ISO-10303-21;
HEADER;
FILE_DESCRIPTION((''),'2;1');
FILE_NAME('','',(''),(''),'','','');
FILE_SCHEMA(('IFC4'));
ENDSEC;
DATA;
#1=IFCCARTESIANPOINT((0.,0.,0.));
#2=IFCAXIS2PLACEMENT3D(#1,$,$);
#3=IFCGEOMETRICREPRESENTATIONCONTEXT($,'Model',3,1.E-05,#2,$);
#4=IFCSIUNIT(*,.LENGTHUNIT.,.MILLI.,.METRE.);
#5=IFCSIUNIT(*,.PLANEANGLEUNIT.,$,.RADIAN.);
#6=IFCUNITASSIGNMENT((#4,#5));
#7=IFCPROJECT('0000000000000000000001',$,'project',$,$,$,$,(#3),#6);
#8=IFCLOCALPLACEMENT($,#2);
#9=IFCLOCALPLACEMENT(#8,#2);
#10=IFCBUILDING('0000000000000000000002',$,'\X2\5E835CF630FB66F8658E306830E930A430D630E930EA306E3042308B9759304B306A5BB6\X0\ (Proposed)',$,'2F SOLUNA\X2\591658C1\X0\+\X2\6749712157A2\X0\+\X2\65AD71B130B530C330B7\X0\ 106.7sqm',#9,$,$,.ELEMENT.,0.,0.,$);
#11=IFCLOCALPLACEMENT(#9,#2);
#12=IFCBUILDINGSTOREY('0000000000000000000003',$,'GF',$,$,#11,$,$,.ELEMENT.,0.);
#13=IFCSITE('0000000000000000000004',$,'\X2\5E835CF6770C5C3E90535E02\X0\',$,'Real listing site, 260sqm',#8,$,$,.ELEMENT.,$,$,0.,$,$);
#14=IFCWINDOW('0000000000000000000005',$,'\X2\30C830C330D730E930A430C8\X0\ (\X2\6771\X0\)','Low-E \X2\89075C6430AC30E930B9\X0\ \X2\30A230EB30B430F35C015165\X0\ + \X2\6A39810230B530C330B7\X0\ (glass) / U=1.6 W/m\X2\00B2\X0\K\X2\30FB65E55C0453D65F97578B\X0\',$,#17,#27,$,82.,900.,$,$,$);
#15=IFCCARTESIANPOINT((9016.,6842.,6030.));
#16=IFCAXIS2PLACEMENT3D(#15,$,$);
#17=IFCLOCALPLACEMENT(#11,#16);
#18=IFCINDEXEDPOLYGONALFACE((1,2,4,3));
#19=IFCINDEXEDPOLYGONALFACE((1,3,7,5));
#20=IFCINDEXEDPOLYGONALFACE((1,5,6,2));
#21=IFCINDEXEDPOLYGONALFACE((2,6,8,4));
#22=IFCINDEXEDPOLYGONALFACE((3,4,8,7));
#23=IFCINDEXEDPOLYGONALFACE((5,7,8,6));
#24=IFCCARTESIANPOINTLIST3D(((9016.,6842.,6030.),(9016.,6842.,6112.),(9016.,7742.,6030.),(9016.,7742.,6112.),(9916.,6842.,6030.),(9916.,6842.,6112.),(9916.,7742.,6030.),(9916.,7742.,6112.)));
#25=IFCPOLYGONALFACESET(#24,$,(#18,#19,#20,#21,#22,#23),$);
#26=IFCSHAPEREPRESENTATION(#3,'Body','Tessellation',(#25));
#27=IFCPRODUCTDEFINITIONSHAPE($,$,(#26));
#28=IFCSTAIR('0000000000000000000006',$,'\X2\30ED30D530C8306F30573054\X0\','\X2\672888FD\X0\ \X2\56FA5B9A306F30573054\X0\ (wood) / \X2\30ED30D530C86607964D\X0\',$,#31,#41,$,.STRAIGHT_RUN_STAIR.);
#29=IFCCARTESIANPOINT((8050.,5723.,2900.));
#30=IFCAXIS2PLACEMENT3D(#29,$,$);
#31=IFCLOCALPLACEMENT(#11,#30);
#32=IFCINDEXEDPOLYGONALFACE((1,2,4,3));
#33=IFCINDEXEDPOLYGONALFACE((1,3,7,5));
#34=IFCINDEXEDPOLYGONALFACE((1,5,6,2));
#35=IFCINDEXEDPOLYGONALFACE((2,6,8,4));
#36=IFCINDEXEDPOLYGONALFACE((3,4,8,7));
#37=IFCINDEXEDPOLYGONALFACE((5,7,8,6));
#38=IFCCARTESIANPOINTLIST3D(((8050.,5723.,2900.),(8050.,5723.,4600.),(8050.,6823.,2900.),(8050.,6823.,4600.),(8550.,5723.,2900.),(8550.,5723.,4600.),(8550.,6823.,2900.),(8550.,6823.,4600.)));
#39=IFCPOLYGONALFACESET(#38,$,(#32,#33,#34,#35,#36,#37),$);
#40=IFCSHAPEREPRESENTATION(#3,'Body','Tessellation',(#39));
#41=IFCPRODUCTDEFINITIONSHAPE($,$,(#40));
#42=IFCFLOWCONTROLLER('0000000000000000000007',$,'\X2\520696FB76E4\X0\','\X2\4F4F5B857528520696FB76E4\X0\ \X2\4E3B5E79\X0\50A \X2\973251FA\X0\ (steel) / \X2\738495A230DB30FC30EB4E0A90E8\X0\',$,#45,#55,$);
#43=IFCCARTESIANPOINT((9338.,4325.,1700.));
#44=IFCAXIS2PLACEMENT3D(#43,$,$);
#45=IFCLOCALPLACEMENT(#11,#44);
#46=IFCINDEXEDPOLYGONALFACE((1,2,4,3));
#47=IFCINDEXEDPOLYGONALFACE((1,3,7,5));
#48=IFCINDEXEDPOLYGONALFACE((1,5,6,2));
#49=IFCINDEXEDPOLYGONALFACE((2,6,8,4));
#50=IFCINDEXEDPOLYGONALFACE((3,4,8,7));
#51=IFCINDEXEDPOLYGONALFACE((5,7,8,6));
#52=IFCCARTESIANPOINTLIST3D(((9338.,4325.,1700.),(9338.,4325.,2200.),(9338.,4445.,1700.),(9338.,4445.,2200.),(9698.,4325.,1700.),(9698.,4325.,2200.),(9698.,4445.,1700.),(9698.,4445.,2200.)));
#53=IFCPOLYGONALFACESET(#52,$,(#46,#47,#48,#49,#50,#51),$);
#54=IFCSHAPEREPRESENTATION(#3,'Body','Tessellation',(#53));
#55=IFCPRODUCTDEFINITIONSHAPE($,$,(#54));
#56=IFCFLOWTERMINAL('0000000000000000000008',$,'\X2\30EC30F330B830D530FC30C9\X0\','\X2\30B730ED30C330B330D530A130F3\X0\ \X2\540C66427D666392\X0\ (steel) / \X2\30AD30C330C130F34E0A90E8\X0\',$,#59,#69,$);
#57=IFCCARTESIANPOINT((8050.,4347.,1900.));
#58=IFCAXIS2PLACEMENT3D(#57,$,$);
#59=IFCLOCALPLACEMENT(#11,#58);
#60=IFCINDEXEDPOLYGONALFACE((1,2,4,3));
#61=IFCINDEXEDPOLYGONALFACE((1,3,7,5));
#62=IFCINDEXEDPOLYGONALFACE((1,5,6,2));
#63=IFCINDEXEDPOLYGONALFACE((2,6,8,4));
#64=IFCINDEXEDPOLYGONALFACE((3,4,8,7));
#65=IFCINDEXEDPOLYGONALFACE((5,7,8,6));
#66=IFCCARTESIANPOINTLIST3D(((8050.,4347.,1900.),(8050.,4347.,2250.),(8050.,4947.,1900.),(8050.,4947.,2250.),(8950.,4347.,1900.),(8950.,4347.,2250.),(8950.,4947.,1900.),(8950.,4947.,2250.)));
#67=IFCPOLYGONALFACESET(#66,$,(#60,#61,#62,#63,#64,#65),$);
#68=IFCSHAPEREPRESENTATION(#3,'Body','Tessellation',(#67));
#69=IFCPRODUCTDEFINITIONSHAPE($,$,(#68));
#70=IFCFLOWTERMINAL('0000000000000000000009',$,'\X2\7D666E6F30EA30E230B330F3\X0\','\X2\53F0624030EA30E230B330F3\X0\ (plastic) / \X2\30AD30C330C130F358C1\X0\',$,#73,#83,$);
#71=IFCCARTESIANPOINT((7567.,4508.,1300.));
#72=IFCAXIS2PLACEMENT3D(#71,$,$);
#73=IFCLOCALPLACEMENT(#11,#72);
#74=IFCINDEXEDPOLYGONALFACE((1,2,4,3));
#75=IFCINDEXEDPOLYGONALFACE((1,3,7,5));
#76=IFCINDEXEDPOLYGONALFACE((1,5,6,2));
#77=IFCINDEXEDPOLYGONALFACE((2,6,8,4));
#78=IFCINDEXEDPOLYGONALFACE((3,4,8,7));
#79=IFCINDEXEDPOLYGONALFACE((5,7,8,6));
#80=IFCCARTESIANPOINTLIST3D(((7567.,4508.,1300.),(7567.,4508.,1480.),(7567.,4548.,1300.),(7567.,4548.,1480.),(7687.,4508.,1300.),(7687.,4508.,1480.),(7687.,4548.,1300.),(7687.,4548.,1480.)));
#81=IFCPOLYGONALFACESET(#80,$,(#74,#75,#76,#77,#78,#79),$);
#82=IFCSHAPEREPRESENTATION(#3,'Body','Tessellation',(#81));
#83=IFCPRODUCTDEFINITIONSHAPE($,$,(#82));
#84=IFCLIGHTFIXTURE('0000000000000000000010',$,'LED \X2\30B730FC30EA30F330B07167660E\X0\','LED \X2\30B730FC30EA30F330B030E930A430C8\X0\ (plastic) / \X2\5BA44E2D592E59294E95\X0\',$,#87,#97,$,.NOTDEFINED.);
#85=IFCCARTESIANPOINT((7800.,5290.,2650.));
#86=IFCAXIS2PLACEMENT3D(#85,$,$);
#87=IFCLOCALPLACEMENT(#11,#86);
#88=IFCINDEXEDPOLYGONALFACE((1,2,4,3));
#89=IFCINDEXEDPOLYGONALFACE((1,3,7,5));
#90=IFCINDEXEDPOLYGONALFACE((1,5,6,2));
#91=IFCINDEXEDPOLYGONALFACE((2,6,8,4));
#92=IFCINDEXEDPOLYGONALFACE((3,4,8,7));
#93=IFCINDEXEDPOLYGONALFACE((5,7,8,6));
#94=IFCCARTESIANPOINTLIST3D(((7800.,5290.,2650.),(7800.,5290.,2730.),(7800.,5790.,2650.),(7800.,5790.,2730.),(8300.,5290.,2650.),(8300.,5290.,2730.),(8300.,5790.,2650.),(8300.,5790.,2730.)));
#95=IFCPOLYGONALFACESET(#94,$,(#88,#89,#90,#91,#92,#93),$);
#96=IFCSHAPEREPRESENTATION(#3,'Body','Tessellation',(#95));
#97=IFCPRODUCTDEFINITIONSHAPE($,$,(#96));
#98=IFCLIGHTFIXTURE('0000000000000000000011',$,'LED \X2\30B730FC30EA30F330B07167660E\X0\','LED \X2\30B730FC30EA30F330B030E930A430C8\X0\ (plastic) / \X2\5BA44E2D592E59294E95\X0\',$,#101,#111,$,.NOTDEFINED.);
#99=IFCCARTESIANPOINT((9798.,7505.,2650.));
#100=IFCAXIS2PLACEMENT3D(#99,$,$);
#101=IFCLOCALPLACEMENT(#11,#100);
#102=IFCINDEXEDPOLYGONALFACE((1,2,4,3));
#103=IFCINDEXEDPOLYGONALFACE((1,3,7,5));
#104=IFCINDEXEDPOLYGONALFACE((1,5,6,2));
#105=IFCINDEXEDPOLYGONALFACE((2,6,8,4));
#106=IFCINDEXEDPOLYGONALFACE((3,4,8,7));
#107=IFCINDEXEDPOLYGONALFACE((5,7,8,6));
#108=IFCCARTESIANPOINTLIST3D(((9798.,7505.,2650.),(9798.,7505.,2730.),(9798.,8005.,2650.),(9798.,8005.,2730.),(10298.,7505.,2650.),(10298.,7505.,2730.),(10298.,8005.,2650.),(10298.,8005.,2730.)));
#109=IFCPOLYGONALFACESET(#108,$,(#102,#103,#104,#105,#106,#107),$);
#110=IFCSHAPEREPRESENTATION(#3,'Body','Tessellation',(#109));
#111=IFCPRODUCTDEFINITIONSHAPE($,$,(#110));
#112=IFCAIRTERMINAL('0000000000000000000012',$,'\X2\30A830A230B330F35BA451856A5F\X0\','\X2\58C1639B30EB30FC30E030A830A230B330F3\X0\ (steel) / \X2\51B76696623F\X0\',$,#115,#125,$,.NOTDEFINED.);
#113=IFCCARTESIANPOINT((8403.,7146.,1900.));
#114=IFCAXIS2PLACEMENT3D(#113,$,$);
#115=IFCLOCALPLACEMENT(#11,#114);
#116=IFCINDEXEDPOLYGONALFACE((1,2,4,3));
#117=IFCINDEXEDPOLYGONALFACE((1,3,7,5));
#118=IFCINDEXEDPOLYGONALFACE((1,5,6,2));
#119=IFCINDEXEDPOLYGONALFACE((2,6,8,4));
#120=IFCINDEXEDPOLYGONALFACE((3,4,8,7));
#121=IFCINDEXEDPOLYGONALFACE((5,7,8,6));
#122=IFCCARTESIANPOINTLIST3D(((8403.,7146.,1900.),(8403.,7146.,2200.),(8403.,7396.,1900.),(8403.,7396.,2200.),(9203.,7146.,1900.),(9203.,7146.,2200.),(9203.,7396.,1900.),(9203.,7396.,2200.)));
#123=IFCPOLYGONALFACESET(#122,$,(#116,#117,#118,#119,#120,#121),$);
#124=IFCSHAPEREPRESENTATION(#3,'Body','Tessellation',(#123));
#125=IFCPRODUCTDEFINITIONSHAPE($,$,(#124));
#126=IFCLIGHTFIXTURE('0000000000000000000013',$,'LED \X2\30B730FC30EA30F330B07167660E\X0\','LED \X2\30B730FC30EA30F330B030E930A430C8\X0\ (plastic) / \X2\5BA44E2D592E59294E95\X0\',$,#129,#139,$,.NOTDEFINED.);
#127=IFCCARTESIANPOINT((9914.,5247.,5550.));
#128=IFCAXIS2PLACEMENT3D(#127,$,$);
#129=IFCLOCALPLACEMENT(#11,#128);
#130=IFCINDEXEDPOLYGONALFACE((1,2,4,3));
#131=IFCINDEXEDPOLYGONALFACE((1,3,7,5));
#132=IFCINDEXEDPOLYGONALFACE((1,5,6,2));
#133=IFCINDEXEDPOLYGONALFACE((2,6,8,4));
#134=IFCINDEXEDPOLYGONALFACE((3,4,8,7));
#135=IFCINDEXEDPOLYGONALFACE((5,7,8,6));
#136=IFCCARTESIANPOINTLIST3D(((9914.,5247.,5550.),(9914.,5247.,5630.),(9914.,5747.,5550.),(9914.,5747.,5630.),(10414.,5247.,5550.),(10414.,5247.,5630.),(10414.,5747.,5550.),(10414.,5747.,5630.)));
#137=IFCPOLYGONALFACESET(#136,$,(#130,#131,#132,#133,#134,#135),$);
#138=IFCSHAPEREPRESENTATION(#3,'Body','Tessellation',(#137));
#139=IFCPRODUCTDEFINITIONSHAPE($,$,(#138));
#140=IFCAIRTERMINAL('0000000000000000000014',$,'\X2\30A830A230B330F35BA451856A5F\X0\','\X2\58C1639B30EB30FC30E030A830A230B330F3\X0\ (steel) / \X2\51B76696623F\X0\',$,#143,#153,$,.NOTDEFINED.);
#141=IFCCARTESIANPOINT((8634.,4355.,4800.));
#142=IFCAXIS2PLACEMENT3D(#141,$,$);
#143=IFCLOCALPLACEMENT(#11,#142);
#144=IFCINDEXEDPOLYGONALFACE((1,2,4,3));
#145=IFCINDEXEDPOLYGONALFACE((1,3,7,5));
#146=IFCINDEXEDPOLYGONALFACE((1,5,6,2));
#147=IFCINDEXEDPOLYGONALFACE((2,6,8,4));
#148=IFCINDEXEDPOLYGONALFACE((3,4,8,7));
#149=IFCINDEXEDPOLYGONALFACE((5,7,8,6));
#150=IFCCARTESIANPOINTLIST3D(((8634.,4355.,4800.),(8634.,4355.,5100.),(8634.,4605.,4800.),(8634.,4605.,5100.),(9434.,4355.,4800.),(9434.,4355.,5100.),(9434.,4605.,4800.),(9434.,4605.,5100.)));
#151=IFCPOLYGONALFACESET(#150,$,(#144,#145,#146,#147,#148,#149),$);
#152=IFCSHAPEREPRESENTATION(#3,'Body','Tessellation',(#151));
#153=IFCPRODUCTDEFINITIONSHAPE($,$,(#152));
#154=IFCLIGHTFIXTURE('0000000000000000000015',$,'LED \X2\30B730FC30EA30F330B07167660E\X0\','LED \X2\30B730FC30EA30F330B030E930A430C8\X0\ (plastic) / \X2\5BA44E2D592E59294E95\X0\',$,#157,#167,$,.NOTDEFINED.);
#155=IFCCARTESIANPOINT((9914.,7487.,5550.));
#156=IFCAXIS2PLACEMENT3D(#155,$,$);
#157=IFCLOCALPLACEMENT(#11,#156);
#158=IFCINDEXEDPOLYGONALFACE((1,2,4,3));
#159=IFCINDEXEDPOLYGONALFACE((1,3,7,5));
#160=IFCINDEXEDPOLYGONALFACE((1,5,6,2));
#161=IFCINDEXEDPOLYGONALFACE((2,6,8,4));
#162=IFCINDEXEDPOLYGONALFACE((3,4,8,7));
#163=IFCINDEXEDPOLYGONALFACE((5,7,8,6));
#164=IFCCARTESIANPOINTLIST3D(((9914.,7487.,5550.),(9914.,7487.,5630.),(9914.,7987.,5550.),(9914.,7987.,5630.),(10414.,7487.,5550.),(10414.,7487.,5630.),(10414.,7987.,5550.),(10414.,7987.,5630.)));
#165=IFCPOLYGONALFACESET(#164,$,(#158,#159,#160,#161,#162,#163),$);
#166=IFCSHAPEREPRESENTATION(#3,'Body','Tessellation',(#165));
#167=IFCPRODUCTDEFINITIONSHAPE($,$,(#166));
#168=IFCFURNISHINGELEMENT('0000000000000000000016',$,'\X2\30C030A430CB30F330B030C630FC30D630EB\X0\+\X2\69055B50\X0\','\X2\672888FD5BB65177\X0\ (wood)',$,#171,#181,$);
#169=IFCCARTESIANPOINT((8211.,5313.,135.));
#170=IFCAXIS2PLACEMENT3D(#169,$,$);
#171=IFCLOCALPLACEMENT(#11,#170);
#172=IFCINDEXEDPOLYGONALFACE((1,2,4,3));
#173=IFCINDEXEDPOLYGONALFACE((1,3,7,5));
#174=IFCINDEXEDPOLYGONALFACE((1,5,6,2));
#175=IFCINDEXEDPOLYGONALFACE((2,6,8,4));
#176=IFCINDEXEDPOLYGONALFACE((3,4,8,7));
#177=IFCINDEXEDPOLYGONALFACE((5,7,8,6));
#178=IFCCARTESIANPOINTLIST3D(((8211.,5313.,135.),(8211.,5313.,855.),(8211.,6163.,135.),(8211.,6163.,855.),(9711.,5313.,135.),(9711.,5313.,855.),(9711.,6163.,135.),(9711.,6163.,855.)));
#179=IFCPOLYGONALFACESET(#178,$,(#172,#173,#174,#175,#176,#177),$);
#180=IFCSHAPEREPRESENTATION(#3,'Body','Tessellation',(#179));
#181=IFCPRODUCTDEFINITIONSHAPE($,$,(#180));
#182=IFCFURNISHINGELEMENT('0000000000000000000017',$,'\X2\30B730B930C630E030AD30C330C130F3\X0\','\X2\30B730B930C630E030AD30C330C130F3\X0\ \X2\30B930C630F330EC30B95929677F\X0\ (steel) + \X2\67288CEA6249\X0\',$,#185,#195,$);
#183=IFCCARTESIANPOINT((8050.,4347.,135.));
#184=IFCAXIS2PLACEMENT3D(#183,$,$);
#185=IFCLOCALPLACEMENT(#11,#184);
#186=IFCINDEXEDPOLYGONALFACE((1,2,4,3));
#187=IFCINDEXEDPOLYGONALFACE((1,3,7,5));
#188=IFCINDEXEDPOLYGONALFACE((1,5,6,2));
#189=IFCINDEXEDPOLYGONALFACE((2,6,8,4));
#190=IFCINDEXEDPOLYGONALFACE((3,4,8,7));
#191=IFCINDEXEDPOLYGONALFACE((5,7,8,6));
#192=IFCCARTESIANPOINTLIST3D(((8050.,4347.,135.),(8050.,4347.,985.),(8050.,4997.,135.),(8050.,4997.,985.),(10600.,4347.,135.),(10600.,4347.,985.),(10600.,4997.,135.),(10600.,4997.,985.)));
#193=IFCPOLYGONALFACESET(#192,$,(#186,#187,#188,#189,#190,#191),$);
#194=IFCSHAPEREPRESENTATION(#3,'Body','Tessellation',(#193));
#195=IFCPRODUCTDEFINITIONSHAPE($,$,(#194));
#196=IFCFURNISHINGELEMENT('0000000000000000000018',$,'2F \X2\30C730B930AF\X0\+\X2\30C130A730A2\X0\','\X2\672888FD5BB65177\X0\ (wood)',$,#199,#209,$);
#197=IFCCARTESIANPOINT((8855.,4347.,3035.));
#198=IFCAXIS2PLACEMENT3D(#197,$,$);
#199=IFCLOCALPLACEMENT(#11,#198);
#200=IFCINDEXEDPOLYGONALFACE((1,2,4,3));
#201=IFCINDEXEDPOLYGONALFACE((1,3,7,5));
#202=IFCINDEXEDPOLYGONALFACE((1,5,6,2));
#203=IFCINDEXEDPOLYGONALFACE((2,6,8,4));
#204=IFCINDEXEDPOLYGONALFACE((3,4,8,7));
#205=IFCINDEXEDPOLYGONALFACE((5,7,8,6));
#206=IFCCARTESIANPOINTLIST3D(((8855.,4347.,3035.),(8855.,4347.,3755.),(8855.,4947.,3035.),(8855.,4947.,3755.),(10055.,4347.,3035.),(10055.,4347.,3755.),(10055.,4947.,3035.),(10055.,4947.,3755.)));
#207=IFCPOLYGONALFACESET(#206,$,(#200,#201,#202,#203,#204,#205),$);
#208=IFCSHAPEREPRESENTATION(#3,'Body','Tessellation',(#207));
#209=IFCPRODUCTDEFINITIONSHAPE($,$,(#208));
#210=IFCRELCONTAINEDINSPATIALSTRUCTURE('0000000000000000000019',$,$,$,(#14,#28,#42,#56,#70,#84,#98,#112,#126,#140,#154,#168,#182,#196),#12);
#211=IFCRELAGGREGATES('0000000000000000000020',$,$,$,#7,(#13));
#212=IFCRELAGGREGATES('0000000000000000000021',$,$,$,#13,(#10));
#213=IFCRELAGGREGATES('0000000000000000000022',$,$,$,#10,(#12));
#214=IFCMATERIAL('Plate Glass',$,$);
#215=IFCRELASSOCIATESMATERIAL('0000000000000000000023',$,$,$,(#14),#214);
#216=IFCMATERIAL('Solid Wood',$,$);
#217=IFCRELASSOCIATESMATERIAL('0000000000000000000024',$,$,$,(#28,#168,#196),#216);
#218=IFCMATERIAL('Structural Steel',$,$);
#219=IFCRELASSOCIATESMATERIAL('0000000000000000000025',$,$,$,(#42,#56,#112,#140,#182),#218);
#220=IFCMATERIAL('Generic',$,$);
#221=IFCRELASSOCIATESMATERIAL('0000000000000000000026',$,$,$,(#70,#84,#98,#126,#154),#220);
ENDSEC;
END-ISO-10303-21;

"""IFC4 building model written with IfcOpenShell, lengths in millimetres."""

from ifc_helpers import new_model, si_unit, frame, frame_2d, origin, place, context, project, spatial, rectangle, extrude, material, element, save


model = new_model("IFC4")

# Units and contexts
model_context = context("Model", 3, precision=1e-05, world=origin())
ifc_project = project(units=[si_unit("LENGTHUNIT", "METRE", prefix="MILLI"), si_unit("PLANEANGLEUNIT", "RADIAN")], contexts=[model_context])

# Site, building, storey
site_placement = place(None, origin())
site = spatial("IfcSite", under=ifc_project, at=site_placement, Name="広島県尾道市", ObjectType="Real listing site, 260sqm", CompositionType="ELEMENT", RefElevation=0.0)
building_placement = place(site_placement, origin())
building = spatial("IfcBuilding", under=site, at=building_placement, Name="広島・書斎とライブラリのある静かな家 (Proposed)", ObjectType="2F SOLUNA外壁+杉無垢+断熱サッシ 106.7sqm", CompositionType="ELEMENT", ElevationOfRefHeight=0.0, ElevationOfTerrain=0.0)
storey_placement = place(building_placement, origin())
storey = spatial("IfcBuildingStorey", under=building, at=storey_placement, Name="GF", CompositionType="ELEMENT", Elevation=0.0)

# Shared definitions
ifc_material_1 = material(Name="Solid Wood")

# Window
ifc_material_2 = material(Name="Plate Glass")
window_placement = place(storey_placement, frame((9016.0, 6842.0, 6030.0)))
element("IfcWindow", 1, at=window_placement, inside=storey, material=ifc_material_2, Name="トップライト (東)", Description="Low-E 複層ガラス アルゴン封入 + 樹脂サッシ (glass) / U=1.6 W/m²K・日射取得型", OverallHeight=82.0, OverallWidth=900.0, context=model_context, shape_type="SweptSolid", body=[
    extrude(rectangle(XDim=900.0, YDim=900.0, at=frame_2d((450.0, 450.0))), frame((9016.0, 6842.0, 6030.0)), (0.0, 0.0, 1.0), 82.0),
])

# Stair
stair_placement = place(storey_placement, frame((8050.0, 5723.0, 2900.0)))
element("IfcStair", 2, at=stair_placement, inside=storey, material=ifc_material_1, Name="ロフトはしご", Description="木製 固定はしご (wood) / ロフト昇降", PredefinedType="STRAIGHT_RUN_STAIR", context=model_context, shape_type="SweptSolid", body=[
    extrude(rectangle(XDim=500.0, YDim=1100.0, at=frame_2d((250.0, 550.0))), frame((8050.0, 5723.0, 2900.0)), (0.0, 0.0, 1.0), 1700.0),
])

# Flow controller
ifc_material_3 = material(Name="Structural Steel")
flow_controller_placement = place(storey_placement, frame((9338.0, 4325.0, 1700.0)))
element("IfcFlowController", 3, at=flow_controller_placement, inside=storey, material=ifc_material_3, Name="分電盤", Description="住宅用分電盤 主幹50A 露出 (steel) / 玄関ホール上部", context=model_context, shape_type="SweptSolid", body=[
    extrude(rectangle(XDim=360.0, YDim=120.0, at=frame_2d((180.0, 60.0))), frame((9338.0, 4325.0, 1700.0)), (0.0, 0.0, 1.0), 500.0),
])

# Flow terminals
flow_terminal_1_placement = place(storey_placement, frame((8050.0, 4347.0, 1900.0)))
element("IfcFlowTerminal", 4, at=flow_terminal_1_placement, inside=storey, material=ifc_material_3, Name="レンジフード", Description="シロッコファン 同時給排 (steel) / キッチン上部", context=model_context, shape_type="SweptSolid", body=[
    extrude(rectangle(XDim=900.0, YDim=600.0, at=frame_2d((450.0, 300.0))), frame((8050.0, 4347.0, 1900.0)), (0.0, 0.0, 1.0), 350.0),
])
ifc_material_4 = material(Name="Generic")
flow_terminal_2_placement = place(storey_placement, frame((7567.0, 4508.0, 1300.0)))
element("IfcFlowTerminal", 5, at=flow_terminal_2_placement, inside=storey, material=ifc_material_4, Name="給湯リモコン", Description="台所リモコン (plastic) / キッチン壁", context=model_context, shape_type="SweptSolid", body=[
    extrude(rectangle(XDim=120.0, YDim=40.0, at=frame_2d((60.0, 20.0))), frame((7567.0, 4508.0, 1300.0)), (0.0, 0.0, 1.0), 180.0),
])

# Light fixtures
light_fixture_1_placement = place(storey_placement, frame((7800.0, 5290.0, 2650.0)))
element("IfcLightFixture", 6, at=light_fixture_1_placement, inside=storey, material=ifc_material_4, Name="LED シーリング照明", Description="LED シーリングライト (plastic) / 室中央天井", PredefinedType="NOTDEFINED", context=model_context, shape_type="SweptSolid", body=[
    extrude(rectangle(XDim=500.0, YDim=500.0, at=frame_2d((250.0, 250.0))), frame((7800.0, 5290.0, 2650.0)), (0.0, 0.0, 1.0), 80.0),
])
light_fixture_2_placement = place(storey_placement, frame((9798.0, 7505.0, 2650.0)))
element("IfcLightFixture", 7, at=light_fixture_2_placement, inside=storey, material=ifc_material_4, Name="LED シーリング照明", Description="LED シーリングライト (plastic) / 室中央天井", PredefinedType="NOTDEFINED", context=model_context, shape_type="SweptSolid", body=[
    extrude(rectangle(XDim=500.0, YDim=500.0, at=frame_2d((250.0, 250.0))), frame((9798.0, 7505.0, 2650.0)), (0.0, 0.0, 1.0), 80.0),
])

# Air terminal
air_terminal_1_placement = place(storey_placement, frame((8403.0, 7146.0, 1900.0)))
element("IfcAirTerminal", 8, at=air_terminal_1_placement, inside=storey, material=ifc_material_3, Name="エアコン室内機", Description="壁掛ルームエアコン (steel) / 冷暖房", PredefinedType="NOTDEFINED", context=model_context, shape_type="SweptSolid", body=[
    extrude(rectangle(XDim=800.0, YDim=250.0, at=frame_2d((400.0, 125.0))), frame((8403.0, 7146.0, 1900.0)), (0.0, 0.0, 1.0), 300.0),
])

# Light fixture
light_fixture_3_placement = place(storey_placement, frame((9914.0, 5247.0, 5550.0)))
element("IfcLightFixture", 9, at=light_fixture_3_placement, inside=storey, material=ifc_material_4, Name="LED シーリング照明", Description="LED シーリングライト (plastic) / 室中央天井", PredefinedType="NOTDEFINED", context=model_context, shape_type="SweptSolid", body=[
    extrude(rectangle(XDim=500.0, YDim=500.0, at=frame_2d((250.0, 250.0))), frame((9914.0, 5247.0, 5550.0)), (0.0, 0.0, 1.0), 80.0),
])

# Air terminal
air_terminal_2_placement = place(storey_placement, frame((8634.0, 4355.0, 4800.0)))
element("IfcAirTerminal", 10, at=air_terminal_2_placement, inside=storey, material=ifc_material_3, Name="エアコン室内機", Description="壁掛ルームエアコン (steel) / 冷暖房", PredefinedType="NOTDEFINED", context=model_context, shape_type="SweptSolid", body=[
    extrude(rectangle(XDim=800.0, YDim=250.0, at=frame_2d((400.0, 125.0))), frame((8634.0, 4355.0, 4800.0)), (0.0, 0.0, 1.0), 300.0),
])

# Light fixture
light_fixture_4_placement = place(storey_placement, frame((9914.0, 7487.0, 5550.0)))
element("IfcLightFixture", 11, at=light_fixture_4_placement, inside=storey, material=ifc_material_4, Name="LED シーリング照明", Description="LED シーリングライト (plastic) / 室中央天井", PredefinedType="NOTDEFINED", context=model_context, shape_type="SweptSolid", body=[
    extrude(rectangle(XDim=500.0, YDim=500.0, at=frame_2d((250.0, 250.0))), frame((9914.0, 7487.0, 5550.0)), (0.0, 0.0, 1.0), 80.0),
])

# Furnishing elements
furnishing_1_placement = place(storey_placement, frame((8211.0, 5313.0, 135.0)))
element("IfcFurnishingElement", 12, at=furnishing_1_placement, inside=storey, material=ifc_material_1, Name="ダイニングテーブル+椅子", Description="木製家具 (wood)", context=model_context, shape_type="SweptSolid", body=[
    extrude(rectangle(XDim=1500.0, YDim=850.0, at=frame_2d((750.0, 425.0))), frame((8211.0, 5313.0, 135.0)), (0.0, 0.0, 1.0), 720.0),
])
furnishing_2_placement = place(storey_placement, frame((8050.0, 4347.0, 135.0)))
element("IfcFurnishingElement", 13, at=furnishing_2_placement, inside=storey, material=ifc_material_3, Name="システムキッチン", Description="システムキッチン ステンレス天板 (steel) + 木質扉", context=model_context, shape_type="SweptSolid", body=[
    extrude(rectangle(XDim=2550.0, YDim=650.0, at=frame_2d((1275.0, 325.0))), frame((8050.0, 4347.0, 135.0)), (0.0, 0.0, 1.0), 850.0),
])
furnishing_3_placement = place(storey_placement, frame((8855.0, 4347.0, 3035.0)))
element("IfcFurnishingElement", 14, at=furnishing_3_placement, inside=storey, material=ifc_material_1, Name="2F デスク+チェア", Description="木製家具 (wood)", context=model_context, shape_type="SweptSolid", body=[
    extrude(rectangle(XDim=1200.0, YDim=600.0, at=frame_2d((600.0, 300.0))), frame((8855.0, 4347.0, 3035.0)), (0.0, 0.0, 1.0), 720.0),
])

save(model, "model.ifc")
